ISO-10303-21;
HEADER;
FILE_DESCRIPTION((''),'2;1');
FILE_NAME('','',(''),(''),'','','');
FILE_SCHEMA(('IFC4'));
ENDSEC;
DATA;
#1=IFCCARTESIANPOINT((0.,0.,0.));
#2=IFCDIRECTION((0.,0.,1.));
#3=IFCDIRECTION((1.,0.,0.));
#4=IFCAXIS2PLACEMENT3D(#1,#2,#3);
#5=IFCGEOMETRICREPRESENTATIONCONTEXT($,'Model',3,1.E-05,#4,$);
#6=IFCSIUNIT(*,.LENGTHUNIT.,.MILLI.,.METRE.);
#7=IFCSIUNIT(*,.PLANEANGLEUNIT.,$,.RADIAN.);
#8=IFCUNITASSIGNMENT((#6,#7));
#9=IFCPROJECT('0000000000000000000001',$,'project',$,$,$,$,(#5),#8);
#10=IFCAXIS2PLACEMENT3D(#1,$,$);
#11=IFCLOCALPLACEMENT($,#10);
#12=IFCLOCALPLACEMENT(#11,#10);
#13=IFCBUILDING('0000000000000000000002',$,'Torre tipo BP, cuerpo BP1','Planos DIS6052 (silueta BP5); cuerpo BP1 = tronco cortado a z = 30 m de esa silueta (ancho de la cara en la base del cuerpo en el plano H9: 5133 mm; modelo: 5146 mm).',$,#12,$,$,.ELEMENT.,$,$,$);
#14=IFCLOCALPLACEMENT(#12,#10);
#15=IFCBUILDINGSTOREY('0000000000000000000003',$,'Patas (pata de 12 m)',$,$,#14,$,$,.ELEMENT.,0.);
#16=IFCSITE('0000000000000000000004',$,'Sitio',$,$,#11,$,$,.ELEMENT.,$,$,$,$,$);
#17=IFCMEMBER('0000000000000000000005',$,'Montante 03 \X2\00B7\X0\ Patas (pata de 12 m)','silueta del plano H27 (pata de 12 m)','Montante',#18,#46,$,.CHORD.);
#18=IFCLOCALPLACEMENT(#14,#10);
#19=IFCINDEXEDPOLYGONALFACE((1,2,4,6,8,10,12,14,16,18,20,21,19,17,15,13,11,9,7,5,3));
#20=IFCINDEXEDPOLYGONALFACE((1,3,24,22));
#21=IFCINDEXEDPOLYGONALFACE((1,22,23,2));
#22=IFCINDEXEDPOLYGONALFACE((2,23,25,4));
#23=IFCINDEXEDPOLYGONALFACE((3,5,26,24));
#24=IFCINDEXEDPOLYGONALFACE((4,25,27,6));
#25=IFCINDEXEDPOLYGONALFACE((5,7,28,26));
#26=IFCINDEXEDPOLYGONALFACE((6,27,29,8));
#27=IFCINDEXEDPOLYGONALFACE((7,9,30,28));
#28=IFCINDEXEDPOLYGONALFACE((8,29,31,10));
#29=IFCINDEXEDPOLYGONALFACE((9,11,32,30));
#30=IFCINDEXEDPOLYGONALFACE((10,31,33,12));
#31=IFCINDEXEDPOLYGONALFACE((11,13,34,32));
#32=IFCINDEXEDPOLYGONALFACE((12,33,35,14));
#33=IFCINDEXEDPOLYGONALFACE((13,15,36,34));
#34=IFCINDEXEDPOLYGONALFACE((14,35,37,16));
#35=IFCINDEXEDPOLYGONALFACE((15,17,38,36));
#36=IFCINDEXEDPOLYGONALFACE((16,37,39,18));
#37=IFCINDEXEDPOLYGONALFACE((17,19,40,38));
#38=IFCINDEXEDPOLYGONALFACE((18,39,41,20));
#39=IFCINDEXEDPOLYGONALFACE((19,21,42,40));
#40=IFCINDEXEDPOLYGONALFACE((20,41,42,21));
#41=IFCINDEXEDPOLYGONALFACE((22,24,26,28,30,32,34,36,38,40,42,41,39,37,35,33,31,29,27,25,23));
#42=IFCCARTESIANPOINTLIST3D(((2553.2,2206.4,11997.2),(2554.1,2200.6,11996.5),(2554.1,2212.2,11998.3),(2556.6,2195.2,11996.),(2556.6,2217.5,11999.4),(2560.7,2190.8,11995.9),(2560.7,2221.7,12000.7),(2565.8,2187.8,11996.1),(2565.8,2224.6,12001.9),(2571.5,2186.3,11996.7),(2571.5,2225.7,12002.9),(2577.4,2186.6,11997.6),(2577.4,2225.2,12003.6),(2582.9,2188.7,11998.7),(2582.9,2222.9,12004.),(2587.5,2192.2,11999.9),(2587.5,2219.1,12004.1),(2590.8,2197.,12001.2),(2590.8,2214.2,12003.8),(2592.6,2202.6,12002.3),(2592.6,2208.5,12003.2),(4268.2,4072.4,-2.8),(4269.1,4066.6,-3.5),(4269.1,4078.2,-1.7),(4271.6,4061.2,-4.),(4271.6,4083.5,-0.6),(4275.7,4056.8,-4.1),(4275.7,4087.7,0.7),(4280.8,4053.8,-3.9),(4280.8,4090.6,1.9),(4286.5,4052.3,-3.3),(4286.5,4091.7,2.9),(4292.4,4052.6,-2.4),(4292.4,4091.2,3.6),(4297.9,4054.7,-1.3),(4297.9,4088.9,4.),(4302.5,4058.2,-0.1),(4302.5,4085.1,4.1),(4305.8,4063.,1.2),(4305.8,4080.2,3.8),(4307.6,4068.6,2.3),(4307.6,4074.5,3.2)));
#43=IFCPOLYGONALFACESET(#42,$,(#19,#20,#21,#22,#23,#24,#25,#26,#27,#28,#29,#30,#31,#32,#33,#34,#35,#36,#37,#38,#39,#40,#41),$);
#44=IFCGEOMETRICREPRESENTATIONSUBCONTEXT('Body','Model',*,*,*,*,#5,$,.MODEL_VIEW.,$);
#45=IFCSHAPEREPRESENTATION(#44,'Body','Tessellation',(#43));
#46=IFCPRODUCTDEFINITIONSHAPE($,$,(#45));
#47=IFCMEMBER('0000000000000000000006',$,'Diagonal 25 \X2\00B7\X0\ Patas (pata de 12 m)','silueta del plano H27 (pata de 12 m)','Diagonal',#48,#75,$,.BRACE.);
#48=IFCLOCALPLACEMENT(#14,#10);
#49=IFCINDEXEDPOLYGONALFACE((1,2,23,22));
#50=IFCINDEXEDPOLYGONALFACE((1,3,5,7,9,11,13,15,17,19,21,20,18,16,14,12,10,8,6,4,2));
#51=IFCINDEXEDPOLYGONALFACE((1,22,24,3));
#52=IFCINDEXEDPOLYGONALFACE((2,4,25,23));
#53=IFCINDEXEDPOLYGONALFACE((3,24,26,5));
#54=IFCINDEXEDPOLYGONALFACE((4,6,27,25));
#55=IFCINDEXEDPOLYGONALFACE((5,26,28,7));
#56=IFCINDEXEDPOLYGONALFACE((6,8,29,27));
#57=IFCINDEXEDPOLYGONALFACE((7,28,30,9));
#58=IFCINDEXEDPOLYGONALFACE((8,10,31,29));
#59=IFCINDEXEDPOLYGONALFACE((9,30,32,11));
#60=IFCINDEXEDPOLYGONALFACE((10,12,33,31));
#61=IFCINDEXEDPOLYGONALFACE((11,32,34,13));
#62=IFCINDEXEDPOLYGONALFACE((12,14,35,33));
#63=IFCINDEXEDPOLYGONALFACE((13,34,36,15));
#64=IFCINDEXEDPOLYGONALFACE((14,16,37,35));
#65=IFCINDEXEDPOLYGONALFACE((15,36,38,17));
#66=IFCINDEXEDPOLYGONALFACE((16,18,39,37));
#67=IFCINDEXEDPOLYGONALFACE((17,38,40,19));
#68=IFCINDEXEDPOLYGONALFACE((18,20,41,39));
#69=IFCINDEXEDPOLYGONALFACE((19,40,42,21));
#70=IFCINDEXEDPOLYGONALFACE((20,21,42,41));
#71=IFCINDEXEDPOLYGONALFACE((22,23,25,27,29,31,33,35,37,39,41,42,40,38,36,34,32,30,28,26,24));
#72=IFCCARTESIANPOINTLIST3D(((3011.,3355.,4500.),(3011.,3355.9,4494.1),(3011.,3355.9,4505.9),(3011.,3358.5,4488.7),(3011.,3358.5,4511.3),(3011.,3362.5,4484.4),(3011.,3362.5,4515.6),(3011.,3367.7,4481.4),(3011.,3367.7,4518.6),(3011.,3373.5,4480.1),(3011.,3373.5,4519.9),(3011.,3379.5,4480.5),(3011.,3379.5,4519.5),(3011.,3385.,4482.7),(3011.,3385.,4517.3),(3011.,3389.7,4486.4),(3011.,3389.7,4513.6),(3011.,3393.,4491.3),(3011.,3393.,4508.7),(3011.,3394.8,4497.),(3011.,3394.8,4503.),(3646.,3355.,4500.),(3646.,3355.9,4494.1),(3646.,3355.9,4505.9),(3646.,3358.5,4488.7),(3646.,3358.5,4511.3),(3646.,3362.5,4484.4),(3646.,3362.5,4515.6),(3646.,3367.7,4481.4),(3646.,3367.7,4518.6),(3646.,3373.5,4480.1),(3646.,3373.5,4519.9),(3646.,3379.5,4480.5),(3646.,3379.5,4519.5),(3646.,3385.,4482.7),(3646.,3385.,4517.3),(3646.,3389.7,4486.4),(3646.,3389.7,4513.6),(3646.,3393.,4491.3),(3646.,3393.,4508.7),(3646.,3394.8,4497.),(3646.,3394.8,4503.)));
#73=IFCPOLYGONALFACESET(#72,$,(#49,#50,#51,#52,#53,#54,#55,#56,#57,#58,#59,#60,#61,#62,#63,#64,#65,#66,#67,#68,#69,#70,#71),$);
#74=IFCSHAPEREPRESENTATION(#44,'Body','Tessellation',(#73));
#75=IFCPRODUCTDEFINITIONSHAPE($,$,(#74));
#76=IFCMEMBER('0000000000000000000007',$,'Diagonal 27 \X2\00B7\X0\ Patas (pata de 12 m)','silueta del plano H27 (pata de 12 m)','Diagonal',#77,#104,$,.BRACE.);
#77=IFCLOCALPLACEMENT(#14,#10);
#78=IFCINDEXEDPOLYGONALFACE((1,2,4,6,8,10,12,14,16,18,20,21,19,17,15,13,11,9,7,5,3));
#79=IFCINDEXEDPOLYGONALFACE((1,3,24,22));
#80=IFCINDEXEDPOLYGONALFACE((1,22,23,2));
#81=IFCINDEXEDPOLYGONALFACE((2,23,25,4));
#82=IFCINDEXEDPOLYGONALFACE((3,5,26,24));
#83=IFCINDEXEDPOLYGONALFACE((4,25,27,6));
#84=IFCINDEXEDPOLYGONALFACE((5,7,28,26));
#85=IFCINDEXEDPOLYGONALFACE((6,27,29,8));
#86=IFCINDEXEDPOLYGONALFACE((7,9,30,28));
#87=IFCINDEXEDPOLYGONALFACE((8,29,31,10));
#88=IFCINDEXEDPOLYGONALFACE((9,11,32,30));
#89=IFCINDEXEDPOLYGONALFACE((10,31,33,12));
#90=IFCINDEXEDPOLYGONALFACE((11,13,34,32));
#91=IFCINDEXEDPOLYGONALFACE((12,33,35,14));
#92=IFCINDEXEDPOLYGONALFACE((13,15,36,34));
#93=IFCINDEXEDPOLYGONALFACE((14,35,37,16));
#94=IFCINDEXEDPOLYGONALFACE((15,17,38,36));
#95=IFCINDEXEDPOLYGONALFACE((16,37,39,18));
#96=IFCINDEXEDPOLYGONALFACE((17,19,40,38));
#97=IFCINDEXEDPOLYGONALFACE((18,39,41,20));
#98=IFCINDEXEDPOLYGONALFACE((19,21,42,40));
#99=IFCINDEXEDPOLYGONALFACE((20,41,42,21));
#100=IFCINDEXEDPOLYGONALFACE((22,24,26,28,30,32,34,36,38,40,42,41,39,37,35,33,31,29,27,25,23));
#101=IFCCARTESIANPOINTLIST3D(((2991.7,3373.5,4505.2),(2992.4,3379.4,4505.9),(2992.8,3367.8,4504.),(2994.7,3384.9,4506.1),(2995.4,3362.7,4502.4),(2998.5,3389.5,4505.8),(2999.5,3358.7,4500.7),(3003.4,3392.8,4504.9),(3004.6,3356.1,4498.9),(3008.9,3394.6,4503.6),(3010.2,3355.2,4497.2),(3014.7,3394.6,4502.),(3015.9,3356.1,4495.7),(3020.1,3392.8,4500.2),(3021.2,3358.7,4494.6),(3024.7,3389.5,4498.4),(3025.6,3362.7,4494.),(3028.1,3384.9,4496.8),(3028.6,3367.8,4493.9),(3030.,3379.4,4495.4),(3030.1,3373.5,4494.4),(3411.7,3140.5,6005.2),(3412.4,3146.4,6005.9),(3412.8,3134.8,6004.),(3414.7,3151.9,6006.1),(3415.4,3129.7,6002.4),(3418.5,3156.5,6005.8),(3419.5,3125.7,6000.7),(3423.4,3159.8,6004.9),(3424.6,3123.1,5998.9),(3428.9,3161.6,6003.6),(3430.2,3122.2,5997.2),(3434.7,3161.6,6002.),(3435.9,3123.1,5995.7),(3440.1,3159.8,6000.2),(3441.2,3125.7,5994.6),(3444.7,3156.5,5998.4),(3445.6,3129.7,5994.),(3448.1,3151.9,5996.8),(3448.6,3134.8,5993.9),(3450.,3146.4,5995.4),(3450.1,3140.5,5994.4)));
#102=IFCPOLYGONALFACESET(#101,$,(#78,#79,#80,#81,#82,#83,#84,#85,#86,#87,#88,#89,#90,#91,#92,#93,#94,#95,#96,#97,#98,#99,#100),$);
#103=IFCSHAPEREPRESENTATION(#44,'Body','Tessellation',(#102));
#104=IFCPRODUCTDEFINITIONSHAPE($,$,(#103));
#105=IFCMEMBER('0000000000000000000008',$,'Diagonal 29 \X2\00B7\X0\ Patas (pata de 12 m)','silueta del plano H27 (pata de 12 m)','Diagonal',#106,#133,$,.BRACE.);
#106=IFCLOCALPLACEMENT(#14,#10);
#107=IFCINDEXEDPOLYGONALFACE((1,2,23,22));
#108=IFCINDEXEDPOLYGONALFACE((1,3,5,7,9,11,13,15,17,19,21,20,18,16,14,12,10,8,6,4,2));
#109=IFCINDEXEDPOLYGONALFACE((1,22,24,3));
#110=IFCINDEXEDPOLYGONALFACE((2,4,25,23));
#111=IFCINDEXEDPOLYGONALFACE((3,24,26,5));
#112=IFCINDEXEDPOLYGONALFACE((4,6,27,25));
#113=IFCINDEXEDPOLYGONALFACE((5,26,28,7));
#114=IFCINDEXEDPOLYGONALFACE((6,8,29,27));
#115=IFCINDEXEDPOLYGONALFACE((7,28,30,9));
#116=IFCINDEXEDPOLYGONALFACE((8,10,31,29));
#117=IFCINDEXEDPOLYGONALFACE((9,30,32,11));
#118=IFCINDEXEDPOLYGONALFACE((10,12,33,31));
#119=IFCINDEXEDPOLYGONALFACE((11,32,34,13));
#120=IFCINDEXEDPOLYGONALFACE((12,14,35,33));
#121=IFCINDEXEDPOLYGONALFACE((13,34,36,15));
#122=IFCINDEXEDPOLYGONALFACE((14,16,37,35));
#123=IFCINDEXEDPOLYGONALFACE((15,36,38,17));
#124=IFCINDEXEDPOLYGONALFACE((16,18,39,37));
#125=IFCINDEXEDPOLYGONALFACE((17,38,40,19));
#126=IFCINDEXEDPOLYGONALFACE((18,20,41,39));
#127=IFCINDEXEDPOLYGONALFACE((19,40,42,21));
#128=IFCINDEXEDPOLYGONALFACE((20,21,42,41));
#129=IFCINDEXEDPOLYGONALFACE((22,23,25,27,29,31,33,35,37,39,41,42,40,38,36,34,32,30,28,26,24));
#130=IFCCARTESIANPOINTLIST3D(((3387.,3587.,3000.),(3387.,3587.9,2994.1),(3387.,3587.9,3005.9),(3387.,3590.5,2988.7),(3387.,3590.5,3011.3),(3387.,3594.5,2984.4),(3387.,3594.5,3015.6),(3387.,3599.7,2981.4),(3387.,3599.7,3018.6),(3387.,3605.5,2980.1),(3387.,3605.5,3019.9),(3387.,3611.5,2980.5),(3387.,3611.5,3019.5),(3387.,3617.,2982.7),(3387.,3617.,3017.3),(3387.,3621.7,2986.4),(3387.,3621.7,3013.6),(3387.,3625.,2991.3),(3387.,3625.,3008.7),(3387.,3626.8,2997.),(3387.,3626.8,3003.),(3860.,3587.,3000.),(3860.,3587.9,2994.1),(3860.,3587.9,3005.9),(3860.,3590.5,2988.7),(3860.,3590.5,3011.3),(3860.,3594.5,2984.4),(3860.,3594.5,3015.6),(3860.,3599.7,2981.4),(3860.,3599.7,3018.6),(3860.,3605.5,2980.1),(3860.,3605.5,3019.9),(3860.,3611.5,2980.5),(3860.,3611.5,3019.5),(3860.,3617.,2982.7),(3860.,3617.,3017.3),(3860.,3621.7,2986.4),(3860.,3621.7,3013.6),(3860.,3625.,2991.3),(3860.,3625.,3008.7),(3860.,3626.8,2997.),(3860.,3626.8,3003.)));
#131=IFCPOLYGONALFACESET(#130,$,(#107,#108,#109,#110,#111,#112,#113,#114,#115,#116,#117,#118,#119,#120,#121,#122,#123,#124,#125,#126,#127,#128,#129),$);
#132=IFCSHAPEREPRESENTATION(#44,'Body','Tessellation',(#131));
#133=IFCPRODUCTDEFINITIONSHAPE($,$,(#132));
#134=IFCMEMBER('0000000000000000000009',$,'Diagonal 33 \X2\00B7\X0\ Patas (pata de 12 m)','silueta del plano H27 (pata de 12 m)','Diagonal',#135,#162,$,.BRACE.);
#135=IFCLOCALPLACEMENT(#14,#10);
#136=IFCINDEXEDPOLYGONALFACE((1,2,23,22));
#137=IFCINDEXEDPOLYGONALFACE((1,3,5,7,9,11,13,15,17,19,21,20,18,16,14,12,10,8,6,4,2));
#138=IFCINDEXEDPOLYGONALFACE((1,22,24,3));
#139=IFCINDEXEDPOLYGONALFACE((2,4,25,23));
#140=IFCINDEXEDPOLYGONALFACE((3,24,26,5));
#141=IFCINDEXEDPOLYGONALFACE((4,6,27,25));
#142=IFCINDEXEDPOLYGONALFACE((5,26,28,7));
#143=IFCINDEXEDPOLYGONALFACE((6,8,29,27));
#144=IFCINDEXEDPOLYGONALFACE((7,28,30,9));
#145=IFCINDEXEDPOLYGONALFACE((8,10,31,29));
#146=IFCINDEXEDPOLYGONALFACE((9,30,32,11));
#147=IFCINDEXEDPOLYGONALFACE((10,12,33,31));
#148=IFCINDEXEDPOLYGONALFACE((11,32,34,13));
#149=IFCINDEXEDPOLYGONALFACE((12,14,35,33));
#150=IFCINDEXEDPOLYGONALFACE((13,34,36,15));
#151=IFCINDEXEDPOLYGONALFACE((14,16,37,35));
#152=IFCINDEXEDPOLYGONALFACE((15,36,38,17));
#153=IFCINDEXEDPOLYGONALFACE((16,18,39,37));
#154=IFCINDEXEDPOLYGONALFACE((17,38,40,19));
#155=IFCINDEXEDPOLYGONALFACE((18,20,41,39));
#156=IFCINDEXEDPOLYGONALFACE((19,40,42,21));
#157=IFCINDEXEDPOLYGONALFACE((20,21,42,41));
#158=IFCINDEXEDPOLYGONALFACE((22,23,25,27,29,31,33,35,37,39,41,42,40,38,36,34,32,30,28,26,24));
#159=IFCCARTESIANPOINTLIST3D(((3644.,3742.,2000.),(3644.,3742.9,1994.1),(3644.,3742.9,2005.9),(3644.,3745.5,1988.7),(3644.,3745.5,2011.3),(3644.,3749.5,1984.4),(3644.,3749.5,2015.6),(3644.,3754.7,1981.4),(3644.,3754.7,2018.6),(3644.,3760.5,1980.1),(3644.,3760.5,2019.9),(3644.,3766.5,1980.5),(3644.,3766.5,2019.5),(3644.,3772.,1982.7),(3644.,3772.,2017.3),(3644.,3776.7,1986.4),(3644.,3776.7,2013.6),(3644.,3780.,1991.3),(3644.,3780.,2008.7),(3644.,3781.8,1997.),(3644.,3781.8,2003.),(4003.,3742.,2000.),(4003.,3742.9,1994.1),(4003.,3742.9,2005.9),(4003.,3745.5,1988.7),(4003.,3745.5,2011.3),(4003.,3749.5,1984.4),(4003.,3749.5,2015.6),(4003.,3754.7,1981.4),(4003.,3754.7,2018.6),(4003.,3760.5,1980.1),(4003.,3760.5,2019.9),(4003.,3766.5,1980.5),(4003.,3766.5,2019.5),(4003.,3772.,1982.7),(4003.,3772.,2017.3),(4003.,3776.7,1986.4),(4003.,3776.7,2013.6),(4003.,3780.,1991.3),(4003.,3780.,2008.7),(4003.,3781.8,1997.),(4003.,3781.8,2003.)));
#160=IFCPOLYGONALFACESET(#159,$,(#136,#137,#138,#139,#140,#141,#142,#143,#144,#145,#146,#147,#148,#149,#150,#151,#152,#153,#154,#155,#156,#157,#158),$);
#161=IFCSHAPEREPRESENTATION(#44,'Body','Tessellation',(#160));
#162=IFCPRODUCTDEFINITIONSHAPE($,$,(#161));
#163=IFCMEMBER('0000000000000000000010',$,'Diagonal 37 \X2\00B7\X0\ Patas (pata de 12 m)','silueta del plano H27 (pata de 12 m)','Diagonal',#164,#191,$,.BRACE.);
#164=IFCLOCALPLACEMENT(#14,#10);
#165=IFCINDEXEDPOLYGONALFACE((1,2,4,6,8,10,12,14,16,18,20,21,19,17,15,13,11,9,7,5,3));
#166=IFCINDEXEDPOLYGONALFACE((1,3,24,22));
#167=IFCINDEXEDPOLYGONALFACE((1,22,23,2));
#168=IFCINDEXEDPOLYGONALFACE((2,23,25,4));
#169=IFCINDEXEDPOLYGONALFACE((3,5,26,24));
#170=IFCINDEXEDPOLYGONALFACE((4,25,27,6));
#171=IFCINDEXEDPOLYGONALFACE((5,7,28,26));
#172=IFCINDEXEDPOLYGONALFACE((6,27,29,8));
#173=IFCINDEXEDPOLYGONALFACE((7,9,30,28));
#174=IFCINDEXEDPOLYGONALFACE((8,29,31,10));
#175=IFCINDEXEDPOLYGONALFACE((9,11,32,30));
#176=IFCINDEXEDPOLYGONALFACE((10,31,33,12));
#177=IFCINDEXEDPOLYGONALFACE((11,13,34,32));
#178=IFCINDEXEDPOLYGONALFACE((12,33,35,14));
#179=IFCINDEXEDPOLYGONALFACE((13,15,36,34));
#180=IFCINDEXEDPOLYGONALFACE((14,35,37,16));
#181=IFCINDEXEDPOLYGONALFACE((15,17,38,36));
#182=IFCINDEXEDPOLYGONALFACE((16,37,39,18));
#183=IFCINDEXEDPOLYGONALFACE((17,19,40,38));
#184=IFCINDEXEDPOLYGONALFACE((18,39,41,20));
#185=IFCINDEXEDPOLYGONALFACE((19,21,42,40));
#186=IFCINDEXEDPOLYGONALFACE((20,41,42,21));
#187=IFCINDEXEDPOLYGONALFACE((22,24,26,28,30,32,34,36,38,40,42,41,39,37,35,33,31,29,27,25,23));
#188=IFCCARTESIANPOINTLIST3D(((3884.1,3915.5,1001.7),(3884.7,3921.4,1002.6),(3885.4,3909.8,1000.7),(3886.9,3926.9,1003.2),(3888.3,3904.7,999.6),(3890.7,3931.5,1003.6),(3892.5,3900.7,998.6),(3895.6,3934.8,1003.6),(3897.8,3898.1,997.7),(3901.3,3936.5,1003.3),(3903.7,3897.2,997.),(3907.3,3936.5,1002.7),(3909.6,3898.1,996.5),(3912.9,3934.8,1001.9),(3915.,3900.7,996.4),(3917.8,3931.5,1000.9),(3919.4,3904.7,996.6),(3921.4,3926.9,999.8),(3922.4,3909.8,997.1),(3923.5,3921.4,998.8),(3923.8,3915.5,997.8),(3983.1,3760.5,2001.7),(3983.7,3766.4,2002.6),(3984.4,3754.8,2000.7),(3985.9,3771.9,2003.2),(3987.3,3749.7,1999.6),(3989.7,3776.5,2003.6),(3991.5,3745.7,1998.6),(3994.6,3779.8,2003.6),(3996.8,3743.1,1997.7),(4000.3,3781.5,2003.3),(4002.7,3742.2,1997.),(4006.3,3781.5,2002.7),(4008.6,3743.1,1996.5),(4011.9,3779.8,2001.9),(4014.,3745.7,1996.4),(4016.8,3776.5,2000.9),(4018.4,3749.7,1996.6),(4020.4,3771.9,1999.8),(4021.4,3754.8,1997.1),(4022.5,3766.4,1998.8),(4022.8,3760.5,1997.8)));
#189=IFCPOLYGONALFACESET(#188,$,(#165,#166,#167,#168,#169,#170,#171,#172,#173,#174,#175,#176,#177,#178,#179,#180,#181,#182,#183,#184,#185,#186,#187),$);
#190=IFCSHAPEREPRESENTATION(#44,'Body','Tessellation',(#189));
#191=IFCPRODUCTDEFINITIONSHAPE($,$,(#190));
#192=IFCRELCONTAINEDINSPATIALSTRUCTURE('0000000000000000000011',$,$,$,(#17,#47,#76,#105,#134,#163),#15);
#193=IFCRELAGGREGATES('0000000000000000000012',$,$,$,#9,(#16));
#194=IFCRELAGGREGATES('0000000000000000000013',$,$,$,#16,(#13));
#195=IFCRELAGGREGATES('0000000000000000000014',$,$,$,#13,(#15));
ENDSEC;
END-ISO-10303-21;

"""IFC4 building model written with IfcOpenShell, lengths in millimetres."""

from ifc_helpers import new_model, si_unit, frame, origin, origin_with_axes, place, context, subcontext, project, spatial, circle, extrude, element, save


model = new_model("IFC4")

# Units and contexts
model_context = context("Model", 3, precision=1e-05, world=origin_with_axes())
body_context = subcontext(model_context, "Body", "Model", "MODEL_VIEW")
ifc_project = project(units=[si_unit("LENGTHUNIT", "METRE", prefix="MILLI"), si_unit("PLANEANGLEUNIT", "RADIAN")], contexts=[model_context])

# Site, building, storey
site_placement = place(None, origin())
site = spatial("IfcSite", under=ifc_project, at=site_placement, Name="Sitio", CompositionType="ELEMENT")
building_placement = place(site_placement, origin())
building = spatial("IfcBuilding", under=site, at=building_placement, Name="Torre tipo BP, cuerpo BP1", Description="Planos DIS6052 (silueta BP5); cuerpo BP1 = tronco cortado a z = 30 m de esa silueta (ancho de la cara en la base del cuerpo en el plano H9: 5133 mm; modelo: 5146 mm).", CompositionType="ELEMENT")
storey_placement = place(building_placement, origin())
storey = spatial("IfcBuildingStorey", under=building, at=storey_placement, Name="Patas (pata de 12 m)", CompositionType="ELEMENT", Elevation=0.0)

# Members
member_1_placement = place(storey_placement, frame((4288.0, 4072.0, 0.0), z_axis=(-0.139832, -0.152144, 0.978417), x_axis=(-0.990175, 0.021486, -0.138172)))
element("IfcMember", 1, at=member_1_placement, inside=storey, Name="Montante 03 · Patas (pata de 12 m)", Description="silueta del plano H27 (pata de 12 m)", ObjectType="Montante", PredefinedType="CHORD", context=body_context, shape_type="SweptSolid", body=[
    extrude(circle(Radius=20.0), None, (0.0, 0.0, 1.0), 12264.7),
])
member_2_placement = place(storey_placement, frame((3646.0, 3375.0, 4500.0), z_axis=(-1.0, 0.0, 0.0), x_axis=(0.0, -1.0, 0.0)))
element("IfcMember", 2, at=member_2_placement, inside=storey, Name="Diagonal 25 · Patas (pata de 12 m)", Description="silueta del plano H27 (pata de 12 m)", ObjectType="Diagonal", PredefinedType="BRACE", context=body_context, shape_type="SweptSolid", body=[
    extrude(circle(Radius=20.0), None, (0.0, 0.0, 1.0), 635.0),
])
member_3_placement = place(storey_placement, frame((3011.0, 3375.0, 4500.0), z_axis=(0.266663, -0.147935, 0.952369), x_axis=(-0.039888, -0.988997, -0.142456)))
element("IfcMember", 3, at=member_3_placement, inside=storey, Name="Diagonal 27 · Patas (pata de 12 m)", Description="silueta del plano H27 (pata de 12 m)", ObjectType="Diagonal", PredefinedType="BRACE", context=body_context, shape_type="SweptSolid", body=[
    extrude(circle(Radius=20.0), None, (0.0, 0.0, 1.0), 1575.0),
])
member_4_placement = place(storey_placement, frame((3860.0, 3607.0, 3000.0), z_axis=(-1.0, 0.0, 0.0), x_axis=(0.0, -1.0, 0.0)))
element("IfcMember", 4, at=member_4_placement, inside=storey, Name="Diagonal 29 · Patas (pata de 12 m)", Description="silueta del plano H27 (pata de 12 m)", ObjectType="Diagonal", PredefinedType="BRACE", context=body_context, shape_type="SweptSolid", body=[
    extrude(circle(Radius=20.0), None, (0.0, 0.0, 1.0), 473.0),
])
member_5_placement = place(storey_placement, frame((4003.0, 3762.0, 2000.0), z_axis=(-1.0, 0.0, 0.0), x_axis=(0.0, -1.0, 0.0)))
element("IfcMember", 5, at=member_5_placement, inside=storey, Name="Diagonal 33 · Patas (pata de 12 m)", Description="silueta del plano H27 (pata de 12 m)", ObjectType="Diagonal", PredefinedType="BRACE", context=body_context, shape_type="SweptSolid", body=[
    extrude(circle(Radius=20.0), None, (0.0, 0.0, 1.0), 359.0),
])
member_6_placement = place(storey_placement, frame((3904.0, 3917.0, 1000.0), z_axis=(0.097367, -0.152443, 0.983504), x_axis=(-0.015018, -0.988312, -0.151702)))
element("IfcMember", 6, at=member_6_placement, inside=storey, Name="Diagonal 37 · Patas (pata de 12 m)", Description="silueta del plano H27 (pata de 12 m)", ObjectType="Diagonal", PredefinedType="BRACE", context=body_context, shape_type="SweptSolid", body=[
    extrude(circle(Radius=20.0), None, (0.0, 0.0, 1.0), 1016.8),
])

save(model, "model.ifc")
